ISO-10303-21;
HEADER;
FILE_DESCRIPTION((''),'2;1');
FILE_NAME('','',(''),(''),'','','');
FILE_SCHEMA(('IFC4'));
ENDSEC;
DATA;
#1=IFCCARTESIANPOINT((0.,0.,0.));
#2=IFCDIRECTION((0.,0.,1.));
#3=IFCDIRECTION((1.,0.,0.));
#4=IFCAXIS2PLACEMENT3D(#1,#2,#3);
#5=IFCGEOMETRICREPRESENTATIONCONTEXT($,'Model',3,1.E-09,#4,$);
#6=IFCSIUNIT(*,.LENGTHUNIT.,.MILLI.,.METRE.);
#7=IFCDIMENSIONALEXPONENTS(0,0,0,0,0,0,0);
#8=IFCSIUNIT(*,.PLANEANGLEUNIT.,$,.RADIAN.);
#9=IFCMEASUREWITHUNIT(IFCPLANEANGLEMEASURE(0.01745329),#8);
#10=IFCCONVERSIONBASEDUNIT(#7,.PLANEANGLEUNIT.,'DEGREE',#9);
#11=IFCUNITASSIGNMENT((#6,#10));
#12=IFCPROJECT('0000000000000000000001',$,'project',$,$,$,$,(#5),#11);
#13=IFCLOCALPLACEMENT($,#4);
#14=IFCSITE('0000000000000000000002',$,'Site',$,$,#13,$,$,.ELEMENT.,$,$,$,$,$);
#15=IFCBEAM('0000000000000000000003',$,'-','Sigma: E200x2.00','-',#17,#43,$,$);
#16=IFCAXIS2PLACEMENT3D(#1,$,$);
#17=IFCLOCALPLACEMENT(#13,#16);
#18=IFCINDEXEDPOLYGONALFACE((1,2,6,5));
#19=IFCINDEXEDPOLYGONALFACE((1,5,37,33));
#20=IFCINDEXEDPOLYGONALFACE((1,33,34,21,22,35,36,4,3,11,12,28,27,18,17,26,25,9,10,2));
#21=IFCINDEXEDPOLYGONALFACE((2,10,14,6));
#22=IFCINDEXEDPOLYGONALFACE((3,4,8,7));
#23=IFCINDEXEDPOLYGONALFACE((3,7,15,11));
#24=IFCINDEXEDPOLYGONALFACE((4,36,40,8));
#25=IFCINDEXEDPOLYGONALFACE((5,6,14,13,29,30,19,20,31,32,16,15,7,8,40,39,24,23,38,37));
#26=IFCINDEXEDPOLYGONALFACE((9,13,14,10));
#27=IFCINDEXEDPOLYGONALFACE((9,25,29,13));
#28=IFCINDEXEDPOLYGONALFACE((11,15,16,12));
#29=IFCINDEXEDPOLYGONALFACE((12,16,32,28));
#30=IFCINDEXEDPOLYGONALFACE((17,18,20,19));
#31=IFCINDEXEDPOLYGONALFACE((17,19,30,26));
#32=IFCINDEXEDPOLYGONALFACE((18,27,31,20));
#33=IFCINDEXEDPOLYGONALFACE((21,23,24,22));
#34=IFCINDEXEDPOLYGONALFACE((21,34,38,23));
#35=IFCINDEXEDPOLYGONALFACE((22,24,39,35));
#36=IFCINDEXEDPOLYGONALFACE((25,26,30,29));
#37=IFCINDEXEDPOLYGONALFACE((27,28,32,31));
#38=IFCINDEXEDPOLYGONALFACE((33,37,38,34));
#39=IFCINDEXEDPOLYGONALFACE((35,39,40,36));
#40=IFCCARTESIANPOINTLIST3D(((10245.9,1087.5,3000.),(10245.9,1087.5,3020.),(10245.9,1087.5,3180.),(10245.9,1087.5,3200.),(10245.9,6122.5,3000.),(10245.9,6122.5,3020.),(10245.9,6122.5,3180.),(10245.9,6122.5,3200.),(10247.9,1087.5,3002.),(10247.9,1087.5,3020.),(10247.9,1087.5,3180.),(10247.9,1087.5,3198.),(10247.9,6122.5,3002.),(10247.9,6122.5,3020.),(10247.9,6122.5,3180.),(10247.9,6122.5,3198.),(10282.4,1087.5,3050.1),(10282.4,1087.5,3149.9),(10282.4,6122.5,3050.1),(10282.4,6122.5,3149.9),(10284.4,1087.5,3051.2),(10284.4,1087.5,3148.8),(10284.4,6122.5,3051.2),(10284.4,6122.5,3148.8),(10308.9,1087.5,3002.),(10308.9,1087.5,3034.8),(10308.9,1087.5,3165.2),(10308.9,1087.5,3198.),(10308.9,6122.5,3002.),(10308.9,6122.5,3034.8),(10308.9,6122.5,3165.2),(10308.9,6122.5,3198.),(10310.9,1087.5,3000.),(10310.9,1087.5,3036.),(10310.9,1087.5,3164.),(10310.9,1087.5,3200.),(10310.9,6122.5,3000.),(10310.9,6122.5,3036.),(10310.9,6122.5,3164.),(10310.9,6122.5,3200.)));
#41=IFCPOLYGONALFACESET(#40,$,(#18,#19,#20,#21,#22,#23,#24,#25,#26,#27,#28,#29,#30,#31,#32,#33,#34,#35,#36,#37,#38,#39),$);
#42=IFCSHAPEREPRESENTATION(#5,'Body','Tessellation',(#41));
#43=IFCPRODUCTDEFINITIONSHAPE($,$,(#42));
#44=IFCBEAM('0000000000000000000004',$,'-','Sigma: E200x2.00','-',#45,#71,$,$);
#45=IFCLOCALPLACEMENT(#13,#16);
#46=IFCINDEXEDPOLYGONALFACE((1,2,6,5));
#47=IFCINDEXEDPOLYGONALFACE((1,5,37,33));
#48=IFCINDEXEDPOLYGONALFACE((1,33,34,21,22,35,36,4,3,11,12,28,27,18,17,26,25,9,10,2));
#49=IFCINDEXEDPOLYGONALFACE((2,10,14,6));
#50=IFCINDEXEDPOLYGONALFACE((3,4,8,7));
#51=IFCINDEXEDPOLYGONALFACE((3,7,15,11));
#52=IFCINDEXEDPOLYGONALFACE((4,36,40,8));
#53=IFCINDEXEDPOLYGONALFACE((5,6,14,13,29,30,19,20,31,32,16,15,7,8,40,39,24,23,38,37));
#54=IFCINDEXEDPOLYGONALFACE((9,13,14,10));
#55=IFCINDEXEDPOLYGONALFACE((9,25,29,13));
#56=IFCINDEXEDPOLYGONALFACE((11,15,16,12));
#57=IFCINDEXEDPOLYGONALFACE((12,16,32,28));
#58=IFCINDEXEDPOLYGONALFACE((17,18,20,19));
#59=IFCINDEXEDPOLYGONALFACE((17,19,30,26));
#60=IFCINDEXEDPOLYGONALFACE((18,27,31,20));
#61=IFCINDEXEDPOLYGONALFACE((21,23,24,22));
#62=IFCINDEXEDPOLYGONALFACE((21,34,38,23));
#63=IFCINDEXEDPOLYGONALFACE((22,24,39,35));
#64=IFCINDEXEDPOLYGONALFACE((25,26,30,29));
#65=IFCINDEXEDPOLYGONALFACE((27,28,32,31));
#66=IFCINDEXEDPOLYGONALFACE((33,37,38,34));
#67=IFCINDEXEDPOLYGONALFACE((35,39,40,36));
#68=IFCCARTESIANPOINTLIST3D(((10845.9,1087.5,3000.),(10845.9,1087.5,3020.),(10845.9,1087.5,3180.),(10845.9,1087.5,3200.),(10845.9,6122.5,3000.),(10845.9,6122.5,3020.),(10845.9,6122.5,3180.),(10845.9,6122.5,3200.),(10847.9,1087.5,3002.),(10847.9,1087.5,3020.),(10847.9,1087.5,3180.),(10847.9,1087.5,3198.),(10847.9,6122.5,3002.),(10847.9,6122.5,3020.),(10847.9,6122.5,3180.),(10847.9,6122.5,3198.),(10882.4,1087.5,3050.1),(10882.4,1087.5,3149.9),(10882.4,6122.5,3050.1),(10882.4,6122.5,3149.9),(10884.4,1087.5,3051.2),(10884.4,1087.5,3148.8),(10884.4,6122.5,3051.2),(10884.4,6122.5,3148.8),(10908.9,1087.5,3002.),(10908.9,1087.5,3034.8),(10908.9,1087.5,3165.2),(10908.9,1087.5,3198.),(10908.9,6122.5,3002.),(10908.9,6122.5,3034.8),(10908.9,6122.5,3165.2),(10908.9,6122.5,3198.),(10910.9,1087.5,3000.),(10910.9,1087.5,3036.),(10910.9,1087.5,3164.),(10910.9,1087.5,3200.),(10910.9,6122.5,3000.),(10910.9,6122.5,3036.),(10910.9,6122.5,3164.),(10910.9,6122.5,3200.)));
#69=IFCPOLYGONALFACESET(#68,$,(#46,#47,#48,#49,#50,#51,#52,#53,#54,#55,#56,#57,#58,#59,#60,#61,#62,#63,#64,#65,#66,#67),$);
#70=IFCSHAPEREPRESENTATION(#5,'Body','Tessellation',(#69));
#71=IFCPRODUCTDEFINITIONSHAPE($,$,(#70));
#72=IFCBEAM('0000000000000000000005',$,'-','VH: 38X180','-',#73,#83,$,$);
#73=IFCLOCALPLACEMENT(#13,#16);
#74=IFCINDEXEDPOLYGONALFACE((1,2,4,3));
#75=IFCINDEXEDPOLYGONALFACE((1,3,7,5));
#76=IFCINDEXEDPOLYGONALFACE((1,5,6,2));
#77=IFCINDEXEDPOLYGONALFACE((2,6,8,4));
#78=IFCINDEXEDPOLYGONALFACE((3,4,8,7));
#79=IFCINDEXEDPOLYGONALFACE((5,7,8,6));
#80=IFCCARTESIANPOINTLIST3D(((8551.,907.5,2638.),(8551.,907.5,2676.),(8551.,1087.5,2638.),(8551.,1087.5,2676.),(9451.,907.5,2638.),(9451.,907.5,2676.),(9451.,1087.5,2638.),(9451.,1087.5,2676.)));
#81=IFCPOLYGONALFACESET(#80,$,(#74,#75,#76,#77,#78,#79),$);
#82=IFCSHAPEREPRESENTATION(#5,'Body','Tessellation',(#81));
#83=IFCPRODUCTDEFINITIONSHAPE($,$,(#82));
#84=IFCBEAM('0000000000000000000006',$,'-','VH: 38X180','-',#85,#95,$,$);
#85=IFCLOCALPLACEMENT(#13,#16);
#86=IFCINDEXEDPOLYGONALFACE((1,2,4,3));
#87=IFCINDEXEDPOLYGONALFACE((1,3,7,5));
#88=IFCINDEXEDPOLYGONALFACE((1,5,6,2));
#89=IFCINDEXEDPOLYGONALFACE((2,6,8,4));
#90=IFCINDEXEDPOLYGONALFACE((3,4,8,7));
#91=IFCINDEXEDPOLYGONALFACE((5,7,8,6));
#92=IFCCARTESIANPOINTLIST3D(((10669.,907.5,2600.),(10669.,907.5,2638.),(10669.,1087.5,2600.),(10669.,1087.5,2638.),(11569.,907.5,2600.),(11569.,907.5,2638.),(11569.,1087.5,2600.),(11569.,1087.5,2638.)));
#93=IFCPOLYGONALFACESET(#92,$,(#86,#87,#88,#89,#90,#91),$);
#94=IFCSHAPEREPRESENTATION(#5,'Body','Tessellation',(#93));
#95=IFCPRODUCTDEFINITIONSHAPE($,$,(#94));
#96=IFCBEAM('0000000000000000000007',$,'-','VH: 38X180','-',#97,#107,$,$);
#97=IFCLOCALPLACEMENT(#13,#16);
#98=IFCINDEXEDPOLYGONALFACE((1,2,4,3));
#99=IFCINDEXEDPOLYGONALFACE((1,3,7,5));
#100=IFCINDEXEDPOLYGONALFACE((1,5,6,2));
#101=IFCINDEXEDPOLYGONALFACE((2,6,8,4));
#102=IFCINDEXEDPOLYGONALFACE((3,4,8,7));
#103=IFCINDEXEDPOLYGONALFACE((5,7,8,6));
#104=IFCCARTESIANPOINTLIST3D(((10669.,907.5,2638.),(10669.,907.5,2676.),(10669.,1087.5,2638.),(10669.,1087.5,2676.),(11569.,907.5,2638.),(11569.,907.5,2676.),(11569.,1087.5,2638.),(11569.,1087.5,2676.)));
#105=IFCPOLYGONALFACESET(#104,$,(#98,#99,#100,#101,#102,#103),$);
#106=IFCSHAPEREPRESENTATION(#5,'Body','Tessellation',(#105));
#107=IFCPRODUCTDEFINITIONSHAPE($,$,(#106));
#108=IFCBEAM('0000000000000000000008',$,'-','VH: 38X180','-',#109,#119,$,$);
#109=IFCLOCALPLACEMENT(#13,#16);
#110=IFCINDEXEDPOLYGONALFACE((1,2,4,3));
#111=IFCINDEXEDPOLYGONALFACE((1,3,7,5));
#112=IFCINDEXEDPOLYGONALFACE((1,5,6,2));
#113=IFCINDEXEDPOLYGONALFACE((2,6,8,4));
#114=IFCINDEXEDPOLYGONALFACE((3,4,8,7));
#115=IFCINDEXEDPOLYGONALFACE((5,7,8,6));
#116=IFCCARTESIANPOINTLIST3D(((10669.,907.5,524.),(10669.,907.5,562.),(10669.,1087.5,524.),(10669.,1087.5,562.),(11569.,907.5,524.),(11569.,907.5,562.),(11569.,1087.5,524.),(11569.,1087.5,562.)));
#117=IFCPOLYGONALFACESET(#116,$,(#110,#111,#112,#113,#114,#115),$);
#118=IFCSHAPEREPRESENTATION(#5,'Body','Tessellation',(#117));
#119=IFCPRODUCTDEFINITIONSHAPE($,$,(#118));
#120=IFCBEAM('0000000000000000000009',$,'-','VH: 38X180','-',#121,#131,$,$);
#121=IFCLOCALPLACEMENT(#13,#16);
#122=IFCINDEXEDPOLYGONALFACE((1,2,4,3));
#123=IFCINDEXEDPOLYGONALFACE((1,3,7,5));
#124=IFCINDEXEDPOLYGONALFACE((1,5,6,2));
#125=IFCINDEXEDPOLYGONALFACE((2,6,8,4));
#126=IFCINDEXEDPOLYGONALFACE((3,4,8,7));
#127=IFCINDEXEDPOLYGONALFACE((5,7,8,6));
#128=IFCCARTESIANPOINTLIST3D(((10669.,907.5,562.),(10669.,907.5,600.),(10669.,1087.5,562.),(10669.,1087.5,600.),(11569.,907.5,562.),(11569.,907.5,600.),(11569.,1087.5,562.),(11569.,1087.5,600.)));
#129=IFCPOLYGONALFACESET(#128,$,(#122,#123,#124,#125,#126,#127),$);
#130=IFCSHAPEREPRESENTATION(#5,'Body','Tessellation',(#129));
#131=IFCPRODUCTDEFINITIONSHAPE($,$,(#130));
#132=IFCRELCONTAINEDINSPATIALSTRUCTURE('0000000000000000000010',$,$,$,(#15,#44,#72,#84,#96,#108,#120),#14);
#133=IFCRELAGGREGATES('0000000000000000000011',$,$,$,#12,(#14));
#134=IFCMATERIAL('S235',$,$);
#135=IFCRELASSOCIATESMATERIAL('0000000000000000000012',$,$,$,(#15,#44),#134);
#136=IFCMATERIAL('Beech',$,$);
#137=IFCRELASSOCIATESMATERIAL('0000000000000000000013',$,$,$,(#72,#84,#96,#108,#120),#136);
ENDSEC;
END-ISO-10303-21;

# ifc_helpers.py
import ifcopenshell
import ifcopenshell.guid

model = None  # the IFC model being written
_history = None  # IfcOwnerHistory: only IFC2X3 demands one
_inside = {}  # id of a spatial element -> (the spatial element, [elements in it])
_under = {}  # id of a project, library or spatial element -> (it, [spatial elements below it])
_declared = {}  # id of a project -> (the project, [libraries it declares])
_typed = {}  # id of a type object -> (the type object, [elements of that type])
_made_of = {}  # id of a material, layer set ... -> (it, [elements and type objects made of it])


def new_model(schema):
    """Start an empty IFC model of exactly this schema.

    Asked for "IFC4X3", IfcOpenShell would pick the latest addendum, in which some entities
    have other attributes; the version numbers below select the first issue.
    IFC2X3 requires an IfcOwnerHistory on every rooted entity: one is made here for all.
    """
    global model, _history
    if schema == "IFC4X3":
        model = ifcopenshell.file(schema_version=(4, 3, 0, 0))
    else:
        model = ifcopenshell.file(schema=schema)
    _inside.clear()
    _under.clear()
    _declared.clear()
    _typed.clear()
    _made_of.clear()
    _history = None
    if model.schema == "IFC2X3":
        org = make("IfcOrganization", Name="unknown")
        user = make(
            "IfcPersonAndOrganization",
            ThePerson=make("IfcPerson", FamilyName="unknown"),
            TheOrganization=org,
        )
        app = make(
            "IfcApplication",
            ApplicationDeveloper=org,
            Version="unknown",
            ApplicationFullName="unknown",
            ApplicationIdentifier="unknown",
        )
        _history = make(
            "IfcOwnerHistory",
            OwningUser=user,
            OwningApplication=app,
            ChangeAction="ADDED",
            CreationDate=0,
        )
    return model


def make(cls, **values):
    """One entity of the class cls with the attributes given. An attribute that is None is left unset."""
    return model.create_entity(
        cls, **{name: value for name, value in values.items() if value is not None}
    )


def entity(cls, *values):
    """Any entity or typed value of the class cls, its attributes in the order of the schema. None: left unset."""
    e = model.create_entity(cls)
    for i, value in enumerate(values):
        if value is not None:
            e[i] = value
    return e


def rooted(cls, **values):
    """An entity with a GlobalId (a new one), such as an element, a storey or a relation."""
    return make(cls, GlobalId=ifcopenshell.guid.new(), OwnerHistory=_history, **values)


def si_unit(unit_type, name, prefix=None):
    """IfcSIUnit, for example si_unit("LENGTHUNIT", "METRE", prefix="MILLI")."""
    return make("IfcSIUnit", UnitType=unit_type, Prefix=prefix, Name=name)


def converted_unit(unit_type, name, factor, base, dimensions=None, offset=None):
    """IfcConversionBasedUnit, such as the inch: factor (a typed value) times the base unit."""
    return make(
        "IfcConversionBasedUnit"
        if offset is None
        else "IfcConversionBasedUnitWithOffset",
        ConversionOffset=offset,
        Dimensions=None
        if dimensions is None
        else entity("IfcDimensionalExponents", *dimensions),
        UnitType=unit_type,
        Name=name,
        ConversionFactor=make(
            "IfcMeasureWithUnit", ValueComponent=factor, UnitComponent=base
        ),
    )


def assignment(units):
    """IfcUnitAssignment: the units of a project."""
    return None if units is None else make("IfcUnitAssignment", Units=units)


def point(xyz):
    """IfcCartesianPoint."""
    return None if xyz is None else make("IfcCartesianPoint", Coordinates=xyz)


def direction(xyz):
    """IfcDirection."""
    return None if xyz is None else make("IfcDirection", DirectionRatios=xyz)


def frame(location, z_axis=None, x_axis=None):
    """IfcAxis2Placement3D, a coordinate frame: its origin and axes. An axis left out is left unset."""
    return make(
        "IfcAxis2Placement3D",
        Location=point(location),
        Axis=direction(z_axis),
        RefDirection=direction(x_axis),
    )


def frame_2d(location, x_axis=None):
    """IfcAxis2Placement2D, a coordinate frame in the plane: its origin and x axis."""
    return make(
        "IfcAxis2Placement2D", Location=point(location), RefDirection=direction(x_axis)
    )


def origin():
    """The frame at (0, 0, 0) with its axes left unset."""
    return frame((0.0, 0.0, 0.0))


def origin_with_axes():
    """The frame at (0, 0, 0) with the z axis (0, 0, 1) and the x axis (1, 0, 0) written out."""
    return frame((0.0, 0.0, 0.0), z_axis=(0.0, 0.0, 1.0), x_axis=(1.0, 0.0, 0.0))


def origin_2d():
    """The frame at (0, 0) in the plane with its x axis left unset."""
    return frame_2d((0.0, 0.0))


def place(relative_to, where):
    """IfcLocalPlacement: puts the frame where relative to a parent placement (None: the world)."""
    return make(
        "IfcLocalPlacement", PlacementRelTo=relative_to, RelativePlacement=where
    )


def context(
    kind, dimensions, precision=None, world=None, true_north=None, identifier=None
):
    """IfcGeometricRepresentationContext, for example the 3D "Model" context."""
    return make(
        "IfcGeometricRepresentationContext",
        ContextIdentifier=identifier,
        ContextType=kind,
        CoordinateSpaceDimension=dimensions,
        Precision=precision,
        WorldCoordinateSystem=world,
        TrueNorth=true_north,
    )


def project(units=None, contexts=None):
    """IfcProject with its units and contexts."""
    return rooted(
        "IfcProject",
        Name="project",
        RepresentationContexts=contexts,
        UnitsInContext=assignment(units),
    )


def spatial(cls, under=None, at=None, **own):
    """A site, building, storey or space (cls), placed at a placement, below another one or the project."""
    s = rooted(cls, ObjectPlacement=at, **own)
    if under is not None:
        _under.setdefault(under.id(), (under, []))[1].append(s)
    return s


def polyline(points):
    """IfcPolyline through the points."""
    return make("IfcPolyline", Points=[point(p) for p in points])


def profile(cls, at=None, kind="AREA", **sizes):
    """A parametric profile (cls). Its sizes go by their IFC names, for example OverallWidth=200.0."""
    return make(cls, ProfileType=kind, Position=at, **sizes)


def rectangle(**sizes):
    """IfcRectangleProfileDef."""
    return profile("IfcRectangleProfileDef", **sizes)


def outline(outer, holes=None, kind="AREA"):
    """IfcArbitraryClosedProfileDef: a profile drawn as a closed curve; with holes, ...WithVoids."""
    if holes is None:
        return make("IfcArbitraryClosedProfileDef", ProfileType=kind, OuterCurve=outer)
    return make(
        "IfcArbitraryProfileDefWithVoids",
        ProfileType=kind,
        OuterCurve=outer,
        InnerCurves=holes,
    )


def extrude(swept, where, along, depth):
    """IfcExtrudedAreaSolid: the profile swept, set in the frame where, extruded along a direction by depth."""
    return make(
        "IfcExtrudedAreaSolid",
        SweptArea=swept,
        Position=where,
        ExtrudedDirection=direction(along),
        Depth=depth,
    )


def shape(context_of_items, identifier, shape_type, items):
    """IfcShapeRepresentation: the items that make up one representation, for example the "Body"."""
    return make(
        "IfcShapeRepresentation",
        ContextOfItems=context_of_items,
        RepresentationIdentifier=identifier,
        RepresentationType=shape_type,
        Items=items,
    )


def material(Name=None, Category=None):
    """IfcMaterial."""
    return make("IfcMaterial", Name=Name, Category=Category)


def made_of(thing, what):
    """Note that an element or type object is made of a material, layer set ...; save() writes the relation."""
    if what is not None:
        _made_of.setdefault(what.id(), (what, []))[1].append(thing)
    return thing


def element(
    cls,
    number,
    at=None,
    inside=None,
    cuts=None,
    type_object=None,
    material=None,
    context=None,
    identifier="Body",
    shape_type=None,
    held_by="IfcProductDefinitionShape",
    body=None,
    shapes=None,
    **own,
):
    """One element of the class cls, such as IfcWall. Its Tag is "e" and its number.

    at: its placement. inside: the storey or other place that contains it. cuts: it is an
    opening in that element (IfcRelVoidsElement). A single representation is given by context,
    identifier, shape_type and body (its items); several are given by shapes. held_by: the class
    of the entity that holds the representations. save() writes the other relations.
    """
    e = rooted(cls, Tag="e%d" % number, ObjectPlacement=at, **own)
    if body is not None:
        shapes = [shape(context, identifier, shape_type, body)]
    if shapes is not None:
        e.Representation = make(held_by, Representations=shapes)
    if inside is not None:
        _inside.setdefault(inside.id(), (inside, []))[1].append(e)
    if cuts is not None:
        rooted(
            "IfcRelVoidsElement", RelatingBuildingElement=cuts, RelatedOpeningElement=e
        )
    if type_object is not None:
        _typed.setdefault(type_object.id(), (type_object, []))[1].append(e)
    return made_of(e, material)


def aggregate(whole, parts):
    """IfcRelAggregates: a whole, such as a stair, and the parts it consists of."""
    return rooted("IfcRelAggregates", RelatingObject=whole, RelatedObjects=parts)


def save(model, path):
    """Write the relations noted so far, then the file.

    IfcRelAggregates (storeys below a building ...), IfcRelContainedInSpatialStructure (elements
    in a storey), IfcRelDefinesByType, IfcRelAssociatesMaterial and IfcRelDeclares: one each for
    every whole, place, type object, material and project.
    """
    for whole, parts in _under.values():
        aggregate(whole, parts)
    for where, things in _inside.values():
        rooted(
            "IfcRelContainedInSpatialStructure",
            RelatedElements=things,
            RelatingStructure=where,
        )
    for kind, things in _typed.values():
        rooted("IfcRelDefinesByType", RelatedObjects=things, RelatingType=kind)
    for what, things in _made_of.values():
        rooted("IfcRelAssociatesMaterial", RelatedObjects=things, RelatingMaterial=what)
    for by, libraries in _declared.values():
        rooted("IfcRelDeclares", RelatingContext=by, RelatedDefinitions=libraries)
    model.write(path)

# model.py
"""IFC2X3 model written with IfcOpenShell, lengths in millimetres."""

from ifc_helpers import new_model, entity, si_unit, converted_unit, frame, origin, origin_with_axes, origin_2d, place, context, project, spatial, polyline, rectangle, outline, extrude, material, element, save


model = new_model("IFC2X3")

# Units and contexts
model_context = context("Model", 3, precision=1e-09, world=origin_with_axes())
ifc_project = project(units=[si_unit("LENGTHUNIT", "METRE", prefix="MILLI"), converted_unit("PLANEANGLEUNIT", "DEGREE", entity("IfcPlaneAngleMeasure", 0.01745329), si_unit("PLANEANGLEUNIT", "RADIAN"), dimensions=[0, 0, 0, 0, 0, 0, 0])], contexts=[model_context])

# Site
site_placement = place(None, origin_with_axes())
site = spatial("IfcSite", under=ifc_project, at=site_placement, Name="Site", CompositionType="ELEMENT")

# Shared definitions
ifc_material_1 = material(Name="Beech")

# Beams
ifc_material_2 = material(Name="S235")
for number, where, z_axis, x_axis, name in (
    (1, (10285.0, 1087.5, 3100.0), (0.0, 1.0, 0.0), (-1.0, 0.0, 0.0), "-"),
    (2, (10885.0, 1087.5, 3100.0), (0.0, 1.0, 0.0), (-1.0, 0.0, 0.0), "-"),
):
    element("IfcBeam", number, at=place(None, frame(where, z_axis=z_axis, x_axis=x_axis)), inside=site, material=ifc_material_2, Name=name, Description="Sigma: E200x2.00", ObjectType="-", context=model_context, shape_type="SweptSolid", body=[
        extrude(outline(polyline([(39.1, -100.0), (39.1, -80.0), (37.1, -80.0), (37.1, -98.0), (-23.9, -98.0), (-23.9, -65.2), (2.6, -49.9), (2.6, 49.9), (-23.9, 65.2), (-23.9, 98.0), (37.1, 98.0), (37.1, 80.0), (39.1, 80.0), (39.1, 100.0), (-25.9, 100.0), (-25.9, 64.0), (0.6, 48.8), (0.6, -48.8), (-25.9, -64.0), (-25.9, -100.0), (39.1, -100.0)])), origin(), (0.0, 0.0, 1.0), 5035.0),
    ])
for number, where, z_axis, x_axis, name in (
    (3, (8551.0, 997.5, 2657.0), (-1.0, 0.0, 0.0), (0.0, 0.0, -1.0), "-"),
    (4, (10669.0, 997.5, 2619.0), (-1.0, 0.0, 0.0), (0.0, 0.0, -1.0), "-"),
    (5, (10669.0, 997.5, 2657.0), (-1.0, 0.0, 0.0), (0.0, 0.0, -1.0), "-"),
    (6, (10669.0, 997.5, 543.0), (-1.0, 0.0, 0.0), (0.0, 0.0, -1.0), "-"),
    (7, (10669.0, 997.5, 581.0), (-1.0, 0.0, 0.0), (0.0, 0.0, -1.0), "-"),
):
    element("IfcBeam", number, at=place(None, frame(where, z_axis=z_axis, x_axis=x_axis)), inside=site, material=ifc_material_1, Name=name, Description="VH: 38X180", ObjectType="-", context=model_context, shape_type="SweptSolid", body=[
        extrude(rectangle(XDim=38.0, YDim=180.0, at=origin_2d()), origin(), (0.0, 0.0, -1.0), 900.0),
    ])

save(model, "model.ifc")
